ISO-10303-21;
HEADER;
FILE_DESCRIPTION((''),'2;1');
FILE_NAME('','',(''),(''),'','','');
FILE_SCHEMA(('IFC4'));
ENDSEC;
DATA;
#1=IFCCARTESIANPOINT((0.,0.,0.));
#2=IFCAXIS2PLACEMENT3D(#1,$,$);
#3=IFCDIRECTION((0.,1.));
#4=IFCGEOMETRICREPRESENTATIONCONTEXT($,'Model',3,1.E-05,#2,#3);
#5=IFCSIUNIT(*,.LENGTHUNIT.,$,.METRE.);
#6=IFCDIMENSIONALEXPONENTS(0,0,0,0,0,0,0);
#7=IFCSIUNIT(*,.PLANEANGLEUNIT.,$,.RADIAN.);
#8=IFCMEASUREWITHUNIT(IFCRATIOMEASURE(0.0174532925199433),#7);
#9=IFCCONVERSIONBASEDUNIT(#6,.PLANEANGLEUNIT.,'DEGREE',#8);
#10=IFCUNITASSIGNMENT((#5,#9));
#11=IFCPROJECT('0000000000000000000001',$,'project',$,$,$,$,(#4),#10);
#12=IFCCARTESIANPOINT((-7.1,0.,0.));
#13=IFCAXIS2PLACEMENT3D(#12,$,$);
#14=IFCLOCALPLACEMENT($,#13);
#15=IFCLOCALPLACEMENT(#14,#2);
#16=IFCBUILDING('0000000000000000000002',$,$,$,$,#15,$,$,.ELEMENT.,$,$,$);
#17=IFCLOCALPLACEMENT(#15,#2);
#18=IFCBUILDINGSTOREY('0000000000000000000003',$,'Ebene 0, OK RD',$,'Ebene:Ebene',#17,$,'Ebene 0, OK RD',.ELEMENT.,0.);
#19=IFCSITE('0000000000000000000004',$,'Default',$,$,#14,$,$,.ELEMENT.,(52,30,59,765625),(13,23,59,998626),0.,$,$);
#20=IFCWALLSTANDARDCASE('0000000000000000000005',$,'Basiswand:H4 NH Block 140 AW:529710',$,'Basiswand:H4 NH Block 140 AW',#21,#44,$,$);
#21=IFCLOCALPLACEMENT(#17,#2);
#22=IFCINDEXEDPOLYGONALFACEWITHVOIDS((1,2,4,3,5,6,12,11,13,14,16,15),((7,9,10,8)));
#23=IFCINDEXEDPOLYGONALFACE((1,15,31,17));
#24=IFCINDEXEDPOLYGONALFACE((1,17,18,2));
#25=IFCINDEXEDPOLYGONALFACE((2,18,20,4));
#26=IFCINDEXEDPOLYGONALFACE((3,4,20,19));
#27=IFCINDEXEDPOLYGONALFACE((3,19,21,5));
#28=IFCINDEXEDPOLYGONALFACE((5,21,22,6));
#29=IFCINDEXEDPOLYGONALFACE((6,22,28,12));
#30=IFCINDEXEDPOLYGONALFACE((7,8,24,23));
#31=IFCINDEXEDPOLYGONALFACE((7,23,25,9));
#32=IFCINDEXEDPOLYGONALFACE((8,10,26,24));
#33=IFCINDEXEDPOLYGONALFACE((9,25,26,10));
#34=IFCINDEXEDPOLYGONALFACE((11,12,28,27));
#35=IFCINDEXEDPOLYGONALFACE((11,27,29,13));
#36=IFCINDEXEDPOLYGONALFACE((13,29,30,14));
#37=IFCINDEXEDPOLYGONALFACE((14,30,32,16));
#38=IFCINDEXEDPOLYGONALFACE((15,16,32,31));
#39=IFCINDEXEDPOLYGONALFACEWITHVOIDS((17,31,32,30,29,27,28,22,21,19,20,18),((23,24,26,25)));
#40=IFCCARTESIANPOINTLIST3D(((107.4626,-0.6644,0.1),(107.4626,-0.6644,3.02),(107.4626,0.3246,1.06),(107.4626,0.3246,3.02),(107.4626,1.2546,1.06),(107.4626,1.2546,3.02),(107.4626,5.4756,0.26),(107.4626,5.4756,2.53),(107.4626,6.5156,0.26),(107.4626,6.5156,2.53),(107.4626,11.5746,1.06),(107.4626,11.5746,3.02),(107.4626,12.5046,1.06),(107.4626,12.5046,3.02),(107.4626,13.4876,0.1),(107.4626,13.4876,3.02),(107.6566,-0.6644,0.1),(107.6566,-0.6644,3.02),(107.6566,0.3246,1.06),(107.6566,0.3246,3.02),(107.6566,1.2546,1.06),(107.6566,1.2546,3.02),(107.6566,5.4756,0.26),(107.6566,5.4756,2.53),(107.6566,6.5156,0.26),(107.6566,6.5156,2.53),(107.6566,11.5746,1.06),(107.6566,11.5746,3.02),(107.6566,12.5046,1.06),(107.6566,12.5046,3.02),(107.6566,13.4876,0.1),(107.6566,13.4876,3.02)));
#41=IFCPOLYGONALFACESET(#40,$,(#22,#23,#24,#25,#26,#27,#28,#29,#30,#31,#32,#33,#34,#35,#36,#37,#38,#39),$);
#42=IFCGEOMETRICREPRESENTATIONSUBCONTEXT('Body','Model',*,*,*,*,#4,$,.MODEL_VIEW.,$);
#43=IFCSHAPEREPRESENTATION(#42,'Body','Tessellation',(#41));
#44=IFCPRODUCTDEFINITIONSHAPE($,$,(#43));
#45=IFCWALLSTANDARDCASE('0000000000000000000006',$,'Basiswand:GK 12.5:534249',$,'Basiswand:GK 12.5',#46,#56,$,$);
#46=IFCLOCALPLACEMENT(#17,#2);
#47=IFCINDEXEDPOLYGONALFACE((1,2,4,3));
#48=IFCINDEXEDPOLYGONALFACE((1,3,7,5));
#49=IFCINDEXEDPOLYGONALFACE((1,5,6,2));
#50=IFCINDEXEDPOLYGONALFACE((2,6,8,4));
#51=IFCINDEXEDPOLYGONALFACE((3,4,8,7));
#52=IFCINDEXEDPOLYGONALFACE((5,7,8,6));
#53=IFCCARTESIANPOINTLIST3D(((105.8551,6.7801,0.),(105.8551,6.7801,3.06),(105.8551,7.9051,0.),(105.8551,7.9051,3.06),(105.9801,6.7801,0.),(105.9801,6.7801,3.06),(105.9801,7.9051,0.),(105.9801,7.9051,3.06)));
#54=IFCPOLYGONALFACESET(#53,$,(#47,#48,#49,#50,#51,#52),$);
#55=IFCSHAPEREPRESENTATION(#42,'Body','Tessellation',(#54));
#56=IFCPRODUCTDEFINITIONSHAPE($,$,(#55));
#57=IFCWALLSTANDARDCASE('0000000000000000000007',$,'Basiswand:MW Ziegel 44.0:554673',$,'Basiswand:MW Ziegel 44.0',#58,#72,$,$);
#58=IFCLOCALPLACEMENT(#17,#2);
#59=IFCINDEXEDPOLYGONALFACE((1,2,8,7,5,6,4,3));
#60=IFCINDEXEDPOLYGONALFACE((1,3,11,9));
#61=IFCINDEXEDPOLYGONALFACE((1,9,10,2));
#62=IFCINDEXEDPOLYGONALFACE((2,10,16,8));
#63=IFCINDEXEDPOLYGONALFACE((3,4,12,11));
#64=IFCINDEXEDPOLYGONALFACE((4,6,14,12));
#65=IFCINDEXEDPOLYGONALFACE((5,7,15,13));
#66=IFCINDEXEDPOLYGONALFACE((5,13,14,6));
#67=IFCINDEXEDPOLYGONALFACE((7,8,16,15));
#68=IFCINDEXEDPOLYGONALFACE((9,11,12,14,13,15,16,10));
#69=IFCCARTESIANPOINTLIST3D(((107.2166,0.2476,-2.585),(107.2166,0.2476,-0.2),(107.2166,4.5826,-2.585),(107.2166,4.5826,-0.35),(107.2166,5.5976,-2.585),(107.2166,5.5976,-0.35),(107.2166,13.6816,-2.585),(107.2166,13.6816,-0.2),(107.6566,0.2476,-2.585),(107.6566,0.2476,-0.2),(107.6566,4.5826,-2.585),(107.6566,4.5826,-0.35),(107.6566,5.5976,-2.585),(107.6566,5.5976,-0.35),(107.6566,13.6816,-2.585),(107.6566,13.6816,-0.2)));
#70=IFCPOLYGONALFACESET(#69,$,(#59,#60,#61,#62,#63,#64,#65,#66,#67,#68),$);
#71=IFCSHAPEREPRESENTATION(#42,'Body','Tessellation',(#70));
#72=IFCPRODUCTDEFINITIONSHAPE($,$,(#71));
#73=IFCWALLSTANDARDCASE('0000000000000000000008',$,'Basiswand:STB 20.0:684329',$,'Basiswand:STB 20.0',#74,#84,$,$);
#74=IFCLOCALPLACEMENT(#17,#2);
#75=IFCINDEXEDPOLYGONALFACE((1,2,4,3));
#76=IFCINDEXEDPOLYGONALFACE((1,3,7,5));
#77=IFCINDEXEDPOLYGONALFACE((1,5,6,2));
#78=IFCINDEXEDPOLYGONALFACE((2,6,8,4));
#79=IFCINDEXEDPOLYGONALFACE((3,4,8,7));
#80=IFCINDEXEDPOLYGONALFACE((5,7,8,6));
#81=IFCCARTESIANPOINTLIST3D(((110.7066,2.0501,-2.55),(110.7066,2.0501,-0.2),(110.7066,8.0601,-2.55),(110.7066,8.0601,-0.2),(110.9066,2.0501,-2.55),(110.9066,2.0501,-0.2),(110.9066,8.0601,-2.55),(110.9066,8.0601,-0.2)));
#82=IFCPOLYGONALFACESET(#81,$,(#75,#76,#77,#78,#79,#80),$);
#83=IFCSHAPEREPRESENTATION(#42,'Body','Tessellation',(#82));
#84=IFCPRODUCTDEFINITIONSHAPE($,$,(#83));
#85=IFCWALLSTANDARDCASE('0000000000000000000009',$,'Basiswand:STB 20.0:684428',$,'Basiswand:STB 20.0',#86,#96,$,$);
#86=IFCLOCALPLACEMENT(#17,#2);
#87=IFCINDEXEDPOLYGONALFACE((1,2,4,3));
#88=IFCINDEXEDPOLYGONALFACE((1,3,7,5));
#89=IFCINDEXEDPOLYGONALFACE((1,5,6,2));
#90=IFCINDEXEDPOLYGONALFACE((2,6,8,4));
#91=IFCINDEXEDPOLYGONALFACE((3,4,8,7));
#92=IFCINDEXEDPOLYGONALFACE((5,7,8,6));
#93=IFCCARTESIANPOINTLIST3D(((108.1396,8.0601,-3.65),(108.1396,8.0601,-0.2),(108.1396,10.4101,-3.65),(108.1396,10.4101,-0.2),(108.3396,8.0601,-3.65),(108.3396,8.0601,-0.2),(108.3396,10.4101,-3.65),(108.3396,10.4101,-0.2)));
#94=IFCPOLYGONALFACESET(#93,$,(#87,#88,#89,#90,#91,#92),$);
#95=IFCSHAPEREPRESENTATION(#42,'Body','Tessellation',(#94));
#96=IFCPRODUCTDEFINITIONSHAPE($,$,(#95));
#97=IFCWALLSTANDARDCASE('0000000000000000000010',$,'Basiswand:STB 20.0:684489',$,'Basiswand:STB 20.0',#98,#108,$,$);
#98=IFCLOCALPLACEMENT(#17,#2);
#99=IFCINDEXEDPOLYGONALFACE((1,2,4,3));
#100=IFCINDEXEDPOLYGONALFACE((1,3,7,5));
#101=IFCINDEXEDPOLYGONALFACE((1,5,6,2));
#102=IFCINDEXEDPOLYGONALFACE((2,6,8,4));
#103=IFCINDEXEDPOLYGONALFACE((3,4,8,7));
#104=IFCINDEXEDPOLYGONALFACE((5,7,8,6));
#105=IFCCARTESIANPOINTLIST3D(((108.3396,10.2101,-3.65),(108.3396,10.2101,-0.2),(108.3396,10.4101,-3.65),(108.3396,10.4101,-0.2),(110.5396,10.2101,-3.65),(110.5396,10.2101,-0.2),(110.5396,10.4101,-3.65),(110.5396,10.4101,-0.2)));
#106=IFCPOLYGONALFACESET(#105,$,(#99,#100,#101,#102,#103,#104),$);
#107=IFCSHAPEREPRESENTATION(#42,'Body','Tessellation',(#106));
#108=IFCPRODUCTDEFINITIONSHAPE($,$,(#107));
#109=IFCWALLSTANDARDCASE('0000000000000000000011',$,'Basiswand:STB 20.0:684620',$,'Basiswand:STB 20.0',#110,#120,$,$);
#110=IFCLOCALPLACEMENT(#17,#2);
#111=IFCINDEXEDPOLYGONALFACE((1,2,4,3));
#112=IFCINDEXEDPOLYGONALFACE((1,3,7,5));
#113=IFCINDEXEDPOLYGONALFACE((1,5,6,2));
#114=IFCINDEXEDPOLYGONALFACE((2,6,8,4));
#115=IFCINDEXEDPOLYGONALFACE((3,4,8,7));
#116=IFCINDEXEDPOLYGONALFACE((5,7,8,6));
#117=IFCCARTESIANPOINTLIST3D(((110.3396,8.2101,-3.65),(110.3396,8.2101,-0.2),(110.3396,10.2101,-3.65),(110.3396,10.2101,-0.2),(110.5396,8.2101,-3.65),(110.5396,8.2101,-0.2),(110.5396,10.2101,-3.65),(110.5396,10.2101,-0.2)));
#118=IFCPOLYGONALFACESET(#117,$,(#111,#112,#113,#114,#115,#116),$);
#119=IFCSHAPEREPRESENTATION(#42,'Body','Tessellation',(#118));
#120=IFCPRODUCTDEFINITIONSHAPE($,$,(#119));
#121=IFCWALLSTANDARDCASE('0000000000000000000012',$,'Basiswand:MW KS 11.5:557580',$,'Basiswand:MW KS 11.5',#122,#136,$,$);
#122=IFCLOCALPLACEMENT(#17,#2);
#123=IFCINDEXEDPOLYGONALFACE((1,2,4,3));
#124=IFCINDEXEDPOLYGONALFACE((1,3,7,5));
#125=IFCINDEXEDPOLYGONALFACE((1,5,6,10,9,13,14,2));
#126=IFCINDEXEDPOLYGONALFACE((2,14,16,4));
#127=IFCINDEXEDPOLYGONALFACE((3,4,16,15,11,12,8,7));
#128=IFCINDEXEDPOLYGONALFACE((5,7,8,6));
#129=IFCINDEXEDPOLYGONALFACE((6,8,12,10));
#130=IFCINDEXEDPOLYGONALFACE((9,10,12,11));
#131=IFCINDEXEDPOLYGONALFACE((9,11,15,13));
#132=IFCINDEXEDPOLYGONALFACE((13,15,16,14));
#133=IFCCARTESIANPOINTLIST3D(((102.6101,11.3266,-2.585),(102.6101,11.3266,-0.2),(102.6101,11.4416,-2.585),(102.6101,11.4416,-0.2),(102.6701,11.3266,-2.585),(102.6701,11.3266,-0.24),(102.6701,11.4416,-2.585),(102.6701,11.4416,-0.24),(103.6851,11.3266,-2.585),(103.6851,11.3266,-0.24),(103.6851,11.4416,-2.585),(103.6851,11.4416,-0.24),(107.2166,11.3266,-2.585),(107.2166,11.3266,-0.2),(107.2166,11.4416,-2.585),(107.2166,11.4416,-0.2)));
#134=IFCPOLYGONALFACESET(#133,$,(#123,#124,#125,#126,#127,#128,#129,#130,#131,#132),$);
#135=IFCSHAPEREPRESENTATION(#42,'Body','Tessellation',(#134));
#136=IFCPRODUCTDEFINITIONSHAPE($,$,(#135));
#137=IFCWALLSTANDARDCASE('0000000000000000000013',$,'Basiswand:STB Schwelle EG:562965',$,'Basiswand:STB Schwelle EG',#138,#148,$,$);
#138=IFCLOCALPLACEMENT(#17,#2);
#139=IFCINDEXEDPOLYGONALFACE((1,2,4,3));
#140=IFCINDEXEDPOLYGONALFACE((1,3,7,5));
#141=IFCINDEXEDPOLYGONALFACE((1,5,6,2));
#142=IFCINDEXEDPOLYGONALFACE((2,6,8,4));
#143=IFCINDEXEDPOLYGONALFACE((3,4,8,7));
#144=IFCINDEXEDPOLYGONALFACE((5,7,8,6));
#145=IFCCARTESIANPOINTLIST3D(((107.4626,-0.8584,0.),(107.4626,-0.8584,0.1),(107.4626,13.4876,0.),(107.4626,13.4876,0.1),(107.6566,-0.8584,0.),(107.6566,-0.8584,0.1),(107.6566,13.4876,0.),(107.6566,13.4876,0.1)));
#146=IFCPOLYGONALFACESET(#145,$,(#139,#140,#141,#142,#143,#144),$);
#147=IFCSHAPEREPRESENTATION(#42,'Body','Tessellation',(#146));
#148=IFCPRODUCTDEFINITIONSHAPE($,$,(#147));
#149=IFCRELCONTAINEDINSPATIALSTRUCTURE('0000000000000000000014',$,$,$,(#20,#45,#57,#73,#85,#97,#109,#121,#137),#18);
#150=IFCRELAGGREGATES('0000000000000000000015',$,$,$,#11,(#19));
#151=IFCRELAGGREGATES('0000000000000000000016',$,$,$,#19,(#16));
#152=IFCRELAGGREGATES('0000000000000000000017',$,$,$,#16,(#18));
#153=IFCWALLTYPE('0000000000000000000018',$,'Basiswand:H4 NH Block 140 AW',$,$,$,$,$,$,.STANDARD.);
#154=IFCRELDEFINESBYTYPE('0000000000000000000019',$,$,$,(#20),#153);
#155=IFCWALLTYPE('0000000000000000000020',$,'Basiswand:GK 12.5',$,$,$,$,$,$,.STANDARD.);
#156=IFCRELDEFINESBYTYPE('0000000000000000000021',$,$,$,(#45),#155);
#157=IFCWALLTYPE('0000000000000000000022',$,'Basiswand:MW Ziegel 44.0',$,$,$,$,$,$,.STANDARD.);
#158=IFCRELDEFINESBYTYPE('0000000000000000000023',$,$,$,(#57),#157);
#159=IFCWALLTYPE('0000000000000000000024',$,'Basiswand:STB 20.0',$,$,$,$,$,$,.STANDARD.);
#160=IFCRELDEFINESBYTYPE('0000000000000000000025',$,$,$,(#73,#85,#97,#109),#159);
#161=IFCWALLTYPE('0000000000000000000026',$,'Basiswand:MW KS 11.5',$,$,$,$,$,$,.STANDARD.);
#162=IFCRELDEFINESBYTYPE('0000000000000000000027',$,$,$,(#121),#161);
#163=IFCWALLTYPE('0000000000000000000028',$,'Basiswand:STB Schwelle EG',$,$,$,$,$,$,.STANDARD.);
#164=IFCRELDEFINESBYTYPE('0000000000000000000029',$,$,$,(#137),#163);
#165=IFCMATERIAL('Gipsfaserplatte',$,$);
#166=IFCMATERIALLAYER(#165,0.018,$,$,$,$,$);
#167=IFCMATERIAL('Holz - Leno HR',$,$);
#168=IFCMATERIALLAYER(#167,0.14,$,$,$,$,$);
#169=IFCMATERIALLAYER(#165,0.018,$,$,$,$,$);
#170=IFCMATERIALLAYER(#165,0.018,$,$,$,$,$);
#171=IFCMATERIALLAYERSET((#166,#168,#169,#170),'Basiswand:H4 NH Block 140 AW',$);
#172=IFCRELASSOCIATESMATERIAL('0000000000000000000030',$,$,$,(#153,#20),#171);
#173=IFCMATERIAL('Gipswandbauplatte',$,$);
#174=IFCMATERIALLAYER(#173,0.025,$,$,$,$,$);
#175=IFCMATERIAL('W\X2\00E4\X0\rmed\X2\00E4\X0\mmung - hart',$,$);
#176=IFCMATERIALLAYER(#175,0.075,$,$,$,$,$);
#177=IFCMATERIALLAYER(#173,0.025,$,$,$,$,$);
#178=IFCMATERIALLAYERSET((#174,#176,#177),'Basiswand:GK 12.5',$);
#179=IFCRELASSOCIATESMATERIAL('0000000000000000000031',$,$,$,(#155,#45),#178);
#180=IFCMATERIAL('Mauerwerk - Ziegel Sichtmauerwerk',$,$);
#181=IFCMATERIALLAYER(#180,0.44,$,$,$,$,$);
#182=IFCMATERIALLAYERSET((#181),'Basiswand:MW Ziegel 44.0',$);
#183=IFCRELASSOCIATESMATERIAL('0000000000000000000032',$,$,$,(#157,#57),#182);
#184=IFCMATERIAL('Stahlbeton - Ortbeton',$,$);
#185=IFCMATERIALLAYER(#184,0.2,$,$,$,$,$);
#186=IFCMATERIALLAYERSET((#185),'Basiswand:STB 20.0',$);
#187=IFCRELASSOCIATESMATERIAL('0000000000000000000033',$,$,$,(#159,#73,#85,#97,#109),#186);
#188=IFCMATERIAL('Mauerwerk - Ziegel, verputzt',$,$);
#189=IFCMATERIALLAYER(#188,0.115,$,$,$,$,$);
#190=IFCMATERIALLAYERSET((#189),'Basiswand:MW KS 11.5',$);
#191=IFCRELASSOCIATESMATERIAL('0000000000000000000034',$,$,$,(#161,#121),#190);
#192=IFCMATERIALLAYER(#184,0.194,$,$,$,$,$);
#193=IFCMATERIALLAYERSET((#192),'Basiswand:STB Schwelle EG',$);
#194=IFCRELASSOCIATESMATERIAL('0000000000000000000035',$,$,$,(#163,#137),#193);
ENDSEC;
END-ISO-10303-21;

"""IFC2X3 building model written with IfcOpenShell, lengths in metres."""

from ifc_helpers import new_model, entity, si_unit, converted_unit, direction, frame, frame_2d, origin, origin_2d_with_axis, place, context, subcontext, project, spatial, rectangle, extrude, material, layer, layer_set, layer_usage, type_object, element, save


model = new_model("IFC2X3")

# Units and contexts
model_context = context("Model", 3, precision=1e-05, world=origin(), true_north=direction((0.0, 1.0)))
body_context = subcontext(model_context, "Body", "Model", "MODEL_VIEW")
ifc_project = project(units=[si_unit("LENGTHUNIT", "METRE"), converted_unit("PLANEANGLEUNIT", "DEGREE", entity("IfcRatioMeasure", 0.0174532925199433), si_unit("PLANEANGLEUNIT", "RADIAN"), dimensions=[0, 0, 0, 0, 0, 0, 0])], contexts=[model_context])

# Site, building, storey
site_placement = place(None, frame((-7.1, 0.0, 0.0)))
site = spatial("IfcSite", under=ifc_project, at=site_placement, Name="Default", CompositionType="ELEMENT", RefLatitude=(52, 30, 59, 765625), RefLongitude=(13, 23, 59, 998626), RefElevation=0.0)
building_placement = place(site_placement, origin())
building = spatial("IfcBuilding", under=site, at=building_placement, CompositionType="ELEMENT")
storey_placement = place(building_placement, origin())
storey = spatial("IfcBuildingStorey", under=building, at=storey_placement, Name="Ebene 0, OK RD", ObjectType="Ebene:Ebene", LongName="Ebene 0, OK RD", CompositionType="ELEMENT", Elevation=0.0)

# Wall, openings
ifc_material_1 = material(Name="Gipsfaserplatte")
ifc_layer_1 = layer(ifc_material_1, 0.018)
ifc_material_2 = material(Name="Holz - Leno HR")
ifc_layer_2 = layer(ifc_material_2, 0.14)
ifc_layer_3 = layer(ifc_material_1, 0.018)
ifc_layer_4 = layer(ifc_material_1, 0.018)
ifc_layer_set_1 = layer_set([ifc_layer_1, ifc_layer_2, ifc_layer_3, ifc_layer_4], Name="Basiswand:H4 NH Block 140 AW")
ifc_layer_usage_1 = layer_usage(ifc_layer_set_1, "AXIS2", "NEGATIVE", 0.097)
wall_type_1 = type_object("IfcWallType", Name="Basiswand:H4 NH Block 140 AW", PredefinedType="STANDARD", material=ifc_layer_set_1)
wall_1_placement = place(storey_placement, frame((107.5596, 13.4876, 0.1), z_axis=(0.0, 0.0, 1.0), x_axis=(0.0, -1.0, 0.0)))
wall_1 = element("IfcWallStandardCase", 1, at=wall_1_placement, inside=storey, type_object=wall_type_1, material=ifc_layer_usage_1, Name="Basiswand:H4 NH Block 140 AW:529710", ObjectType="Basiswand:H4 NH Block 140 AW", context=body_context, shape_type="SweptSolid", body=[
    extrude(rectangle(XDim=14.152, YDim=0.194, at=frame_2d((7.076, 0.0), x_axis=(-1.0, 0.0))), origin(), (0.0, 0.0, 1.0), 2.92),
])
opening_1_placement = place(wall_1_placement, origin())
element("IfcOpeningElement", 2, at=opening_1_placement, cuts=wall_1, ObjectType="Opening", context=body_context, shape_type="SweptSolid", body=[
    extrude(rectangle(XDim=2.0, YDim=0.93, at=origin_2d_with_axis()), frame((1.448, -0.097, 1.96), z_axis=(0.0, 1.0, 0.0), x_axis=(0.0, 0.0, -1.0)), (0.0, 0.0, 1.0), 0.194),
])
opening_2_placement = place(wall_1_placement, origin())
element("IfcOpeningElement", 3, at=opening_2_placement, cuts=wall_1, ObjectType="Opening", context=body_context, shape_type="SweptSolid", body=[
    extrude(rectangle(XDim=2.0, YDim=0.93, at=origin_2d_with_axis()), frame((12.698, -0.097, 1.96), z_axis=(0.0, 1.0, 0.0), x_axis=(0.0, 0.0, -1.0)), (0.0, 0.0, 1.0), 0.194),
])
opening_3_placement = place(wall_1_placement, origin())
element("IfcOpeningElement", 4, at=opening_3_placement, cuts=wall_1, ObjectType="Opening", context=body_context, shape_type="SweptSolid", body=[
    extrude(rectangle(XDim=2.27, YDim=1.04, at=origin_2d_with_axis()), frame((7.492, -0.097, 1.295), z_axis=(0.0, 1.0, 0.0), x_axis=(0.0, 0.0, -1.0)), (0.0, 0.0, 1.0), 0.194),
])

# Wall
ifc_material_3 = material(Name="Gipswandbauplatte")
ifc_layer_5 = layer(ifc_material_3, 0.025)
ifc_material_4 = material(Name="Wärmedämmung - hart")
ifc_layer_6 = layer(ifc_material_4, 0.075)
ifc_layer_7 = layer(ifc_material_3, 0.025)
ifc_layer_set_2 = layer_set([ifc_layer_5, ifc_layer_6, ifc_layer_7], Name="Basiswand:GK 12.5")
ifc_layer_usage_2 = layer_usage(ifc_layer_set_2, "AXIS2", "NEGATIVE", 0.0625)
wall_type_2 = type_object("IfcWallType", Name="Basiswand:GK 12.5", PredefinedType="STANDARD", material=ifc_layer_set_2)
wall_2_placement = place(storey_placement, frame((105.9176, 7.9051, 0.0), z_axis=(0.0, 0.0, 1.0), x_axis=(0.0, -1.0, 0.0)))
element("IfcWallStandardCase", 5, at=wall_2_placement, inside=storey, type_object=wall_type_2, material=ifc_layer_usage_2, Name="Basiswand:GK 12.5:534249", ObjectType="Basiswand:GK 12.5", context=body_context, shape_type="SweptSolid", body=[
    extrude(rectangle(XDim=1.125, YDim=0.125, at=frame_2d((0.5625, 0.0), x_axis=(-1.0, 0.0))), origin(), (0.0, 0.0, 1.0), 3.06),
])

# Wall, opening
ifc_material_5 = material(Name="Mauerwerk - Ziegel Sichtmauerwerk")
ifc_layer_8 = layer(ifc_material_5, 0.44)
ifc_layer_set_3 = layer_set([ifc_layer_8], Name="Basiswand:MW Ziegel 44.0")
ifc_layer_usage_3 = layer_usage(ifc_layer_set_3, "AXIS2", "NEGATIVE", 0.22)
wall_type_3 = type_object("IfcWallType", Name="Basiswand:MW Ziegel 44.0", PredefinedType="STANDARD", material=ifc_layer_set_3)
wall_3_placement = place(storey_placement, frame((107.4366, 13.6816, -2.585), z_axis=(0.0, 0.0, 1.0), x_axis=(0.0, -1.0, 0.0)))
wall_3 = element("IfcWallStandardCase", 6, at=wall_3_placement, inside=storey, type_object=wall_type_3, material=ifc_layer_usage_3, Name="Basiswand:MW Ziegel 44.0:554673", ObjectType="Basiswand:MW Ziegel 44.0", context=body_context, shape_type="SweptSolid", body=[
    extrude(rectangle(XDim=13.434, YDim=0.44, at=frame_2d((6.717, 0.0), x_axis=(-1.0, 0.0))), origin(), (0.0, 0.0, 1.0), 2.385),
])
opening_4_placement = place(wall_3_placement, frame((9.099, 0.22, 0.0)))
element("IfcOpeningElement", 7, at=opening_4_placement, cuts=wall_3, ObjectType="Opening", context=body_context, shape_type="SweptSolid", body=[
    extrude(rectangle(XDim=2.235, YDim=1.015, at=frame_2d((1.1175, 0.5075), x_axis=(1.0, 0.0))), frame((0.0, 0.0, 0.0), z_axis=(0.0, -1.0, 0.0), x_axis=(0.0, 0.0, 1.0)), (0.0, 0.0, 1.0), 0.44),
])

# Walls
ifc_material_6 = material(Name="Stahlbeton - Ortbeton")
ifc_layer_9 = layer(ifc_material_6, 0.2)
ifc_layer_set_4 = layer_set([ifc_layer_9], Name="Basiswand:STB 20.0")
ifc_layer_usage_4 = layer_usage(ifc_layer_set_4, "AXIS2", "NEGATIVE", 0.1)
wall_type_4 = type_object("IfcWallType", Name="Basiswand:STB 20.0", PredefinedType="STANDARD", material=ifc_layer_set_4)
wall_4_placement = place(storey_placement, frame((110.8066, 8.0601, -2.55), z_axis=(0.0, 0.0, 1.0), x_axis=(0.0, -1.0, 0.0)))
element("IfcWallStandardCase", 8, at=wall_4_placement, inside=storey, type_object=wall_type_4, material=ifc_layer_usage_4, Name="Basiswand:STB 20.0:684329", ObjectType="Basiswand:STB 20.0", context=body_context, shape_type="SweptSolid", body=[
    extrude(rectangle(XDim=6.01, YDim=0.2, at=frame_2d((3.005, 0.0), x_axis=(-1.0, 0.0))), origin(), (0.0, 0.0, 1.0), 2.35),
])
ifc_layer_usage_5 = layer_usage(ifc_layer_set_4, "AXIS2", "NEGATIVE", 0.1)
wall_5_placement = place(storey_placement, frame((108.2396, 8.0601, -3.65), z_axis=(0.0, 0.0, 1.0), x_axis=(0.0, 1.0, 0.0)))
element("IfcWallStandardCase", 9, at=wall_5_placement, inside=storey, type_object=wall_type_4, material=ifc_layer_usage_5, Name="Basiswand:STB 20.0:684428", ObjectType="Basiswand:STB 20.0", context=body_context, shape_type="SweptSolid", body=[
    extrude(rectangle(XDim=2.35, YDim=0.2, at=frame_2d((1.175, 0.0), x_axis=(-1.0, 0.0))), origin(), (0.0, 0.0, 1.0), 3.45),
])
ifc_layer_usage_6 = layer_usage(ifc_layer_set_4, "AXIS2", "NEGATIVE", 0.1)
wall_6_placement = place(storey_placement, frame((108.3396, 10.3101, -3.65)))
element("IfcWallStandardCase", 10, at=wall_6_placement, inside=storey, type_object=wall_type_4, material=ifc_layer_usage_6, Name="Basiswand:STB 20.0:684489", ObjectType="Basiswand:STB 20.0", context=body_context, shape_type="SweptSolid", body=[
    extrude(rectangle(XDim=2.2, YDim=0.2, at=frame_2d((1.1, 0.0), x_axis=(-1.0, 0.0))), origin(), (0.0, 0.0, 1.0), 3.45),
])
ifc_layer_usage_7 = layer_usage(ifc_layer_set_4, "AXIS2", "NEGATIVE", 0.1)
wall_7_placement = place(storey_placement, frame((110.4396, 10.2101, -3.65), z_axis=(0.0, 0.0, 1.0), x_axis=(0.0, -1.0, 0.0)))
element("IfcWallStandardCase", 11, at=wall_7_placement, inside=storey, type_object=wall_type_4, material=ifc_layer_usage_7, Name="Basiswand:STB 20.0:684620", ObjectType="Basiswand:STB 20.0", context=body_context, shape_type="SweptSolid", body=[
    extrude(rectangle(XDim=2.0, YDim=0.2, at=frame_2d((1.0, 0.0), x_axis=(-1.0, 0.0))), origin(), (0.0, 0.0, 1.0), 3.45),
])

# Wall, opening
ifc_material_7 = material(Name="Mauerwerk - Ziegel, verputzt")
ifc_layer_10 = layer(ifc_material_7, 0.115)
ifc_layer_set_5 = layer_set([ifc_layer_10], Name="Basiswand:MW KS 11.5")
ifc_layer_usage_8 = layer_usage(ifc_layer_set_5, "AXIS2", "NEGATIVE", 0.0575)
wall_type_5 = type_object("IfcWallType", Name="Basiswand:MW KS 11.5", PredefinedType="STANDARD", material=ifc_layer_set_5)
wall_8_placement = place(storey_placement, frame((107.2166, 11.3841, -2.585), z_axis=(0.0, 0.0, 1.0), x_axis=(-1.0, 0.0, 0.0)))
wall_8 = element("IfcWallStandardCase", 12, at=wall_8_placement, inside=storey, type_object=wall_type_5, material=ifc_layer_usage_8, Name="Basiswand:MW KS 11.5:557580", ObjectType="Basiswand:MW KS 11.5", context=body_context, shape_type="SweptSolid", body=[
    extrude(rectangle(XDim=4.6065, YDim=0.115, at=frame_2d((2.3033, 0.0), x_axis=(-1.0, 0.0))), origin(), (0.0, 0.0, 1.0), 2.385),
])
opening_5_placement = place(wall_8_placement, frame((4.5465, 0.0575, 0.0)))
element("IfcOpeningElement", 13, at=opening_5_placement, cuts=wall_8, ObjectType="Opening", context=body_context, shape_type="SweptSolid", body=[
    extrude(rectangle(XDim=2.345, YDim=1.015, at=frame_2d((1.1725, 0.5075), x_axis=(1.0, 0.0))), frame((0.0, 0.0, 0.0), z_axis=(0.0, -1.0, 0.0), x_axis=(0.0, 0.0, 1.0)), (0.0, 0.0, 1.0), 0.115),
])

# Wall
ifc_layer_11 = layer(ifc_material_6, 0.194)
ifc_layer_set_6 = layer_set([ifc_layer_11], Name="Basiswand:STB Schwelle EG")
ifc_layer_usage_9 = layer_usage(ifc_layer_set_6, "AXIS2", "NEGATIVE", 0.097)
wall_type_6 = type_object("IfcWallType", Name="Basiswand:STB Schwelle EG", PredefinedType="STANDARD", material=ifc_layer_set_6)
wall_9_placement = place(storey_placement, frame((107.5596, 13.4876, 0.0), z_axis=(0.0, 0.0, 1.0), x_axis=(0.0, -1.0, 0.0)))
element("IfcWallStandardCase", 14, at=wall_9_placement, inside=storey, type_object=wall_type_6, material=ifc_layer_usage_9, Name="Basiswand:STB Schwelle EG:562965", ObjectType="Basiswand:STB Schwelle EG", context=body_context, shape_type="SweptSolid", body=[
    extrude(rectangle(XDim=14.346, YDim=0.194, at=frame_2d((7.173, 0.0), x_axis=(-1.0, 0.0))), origin(), (0.0, 0.0, 1.0), 0.1),
])

save(model, "model.ifc")
